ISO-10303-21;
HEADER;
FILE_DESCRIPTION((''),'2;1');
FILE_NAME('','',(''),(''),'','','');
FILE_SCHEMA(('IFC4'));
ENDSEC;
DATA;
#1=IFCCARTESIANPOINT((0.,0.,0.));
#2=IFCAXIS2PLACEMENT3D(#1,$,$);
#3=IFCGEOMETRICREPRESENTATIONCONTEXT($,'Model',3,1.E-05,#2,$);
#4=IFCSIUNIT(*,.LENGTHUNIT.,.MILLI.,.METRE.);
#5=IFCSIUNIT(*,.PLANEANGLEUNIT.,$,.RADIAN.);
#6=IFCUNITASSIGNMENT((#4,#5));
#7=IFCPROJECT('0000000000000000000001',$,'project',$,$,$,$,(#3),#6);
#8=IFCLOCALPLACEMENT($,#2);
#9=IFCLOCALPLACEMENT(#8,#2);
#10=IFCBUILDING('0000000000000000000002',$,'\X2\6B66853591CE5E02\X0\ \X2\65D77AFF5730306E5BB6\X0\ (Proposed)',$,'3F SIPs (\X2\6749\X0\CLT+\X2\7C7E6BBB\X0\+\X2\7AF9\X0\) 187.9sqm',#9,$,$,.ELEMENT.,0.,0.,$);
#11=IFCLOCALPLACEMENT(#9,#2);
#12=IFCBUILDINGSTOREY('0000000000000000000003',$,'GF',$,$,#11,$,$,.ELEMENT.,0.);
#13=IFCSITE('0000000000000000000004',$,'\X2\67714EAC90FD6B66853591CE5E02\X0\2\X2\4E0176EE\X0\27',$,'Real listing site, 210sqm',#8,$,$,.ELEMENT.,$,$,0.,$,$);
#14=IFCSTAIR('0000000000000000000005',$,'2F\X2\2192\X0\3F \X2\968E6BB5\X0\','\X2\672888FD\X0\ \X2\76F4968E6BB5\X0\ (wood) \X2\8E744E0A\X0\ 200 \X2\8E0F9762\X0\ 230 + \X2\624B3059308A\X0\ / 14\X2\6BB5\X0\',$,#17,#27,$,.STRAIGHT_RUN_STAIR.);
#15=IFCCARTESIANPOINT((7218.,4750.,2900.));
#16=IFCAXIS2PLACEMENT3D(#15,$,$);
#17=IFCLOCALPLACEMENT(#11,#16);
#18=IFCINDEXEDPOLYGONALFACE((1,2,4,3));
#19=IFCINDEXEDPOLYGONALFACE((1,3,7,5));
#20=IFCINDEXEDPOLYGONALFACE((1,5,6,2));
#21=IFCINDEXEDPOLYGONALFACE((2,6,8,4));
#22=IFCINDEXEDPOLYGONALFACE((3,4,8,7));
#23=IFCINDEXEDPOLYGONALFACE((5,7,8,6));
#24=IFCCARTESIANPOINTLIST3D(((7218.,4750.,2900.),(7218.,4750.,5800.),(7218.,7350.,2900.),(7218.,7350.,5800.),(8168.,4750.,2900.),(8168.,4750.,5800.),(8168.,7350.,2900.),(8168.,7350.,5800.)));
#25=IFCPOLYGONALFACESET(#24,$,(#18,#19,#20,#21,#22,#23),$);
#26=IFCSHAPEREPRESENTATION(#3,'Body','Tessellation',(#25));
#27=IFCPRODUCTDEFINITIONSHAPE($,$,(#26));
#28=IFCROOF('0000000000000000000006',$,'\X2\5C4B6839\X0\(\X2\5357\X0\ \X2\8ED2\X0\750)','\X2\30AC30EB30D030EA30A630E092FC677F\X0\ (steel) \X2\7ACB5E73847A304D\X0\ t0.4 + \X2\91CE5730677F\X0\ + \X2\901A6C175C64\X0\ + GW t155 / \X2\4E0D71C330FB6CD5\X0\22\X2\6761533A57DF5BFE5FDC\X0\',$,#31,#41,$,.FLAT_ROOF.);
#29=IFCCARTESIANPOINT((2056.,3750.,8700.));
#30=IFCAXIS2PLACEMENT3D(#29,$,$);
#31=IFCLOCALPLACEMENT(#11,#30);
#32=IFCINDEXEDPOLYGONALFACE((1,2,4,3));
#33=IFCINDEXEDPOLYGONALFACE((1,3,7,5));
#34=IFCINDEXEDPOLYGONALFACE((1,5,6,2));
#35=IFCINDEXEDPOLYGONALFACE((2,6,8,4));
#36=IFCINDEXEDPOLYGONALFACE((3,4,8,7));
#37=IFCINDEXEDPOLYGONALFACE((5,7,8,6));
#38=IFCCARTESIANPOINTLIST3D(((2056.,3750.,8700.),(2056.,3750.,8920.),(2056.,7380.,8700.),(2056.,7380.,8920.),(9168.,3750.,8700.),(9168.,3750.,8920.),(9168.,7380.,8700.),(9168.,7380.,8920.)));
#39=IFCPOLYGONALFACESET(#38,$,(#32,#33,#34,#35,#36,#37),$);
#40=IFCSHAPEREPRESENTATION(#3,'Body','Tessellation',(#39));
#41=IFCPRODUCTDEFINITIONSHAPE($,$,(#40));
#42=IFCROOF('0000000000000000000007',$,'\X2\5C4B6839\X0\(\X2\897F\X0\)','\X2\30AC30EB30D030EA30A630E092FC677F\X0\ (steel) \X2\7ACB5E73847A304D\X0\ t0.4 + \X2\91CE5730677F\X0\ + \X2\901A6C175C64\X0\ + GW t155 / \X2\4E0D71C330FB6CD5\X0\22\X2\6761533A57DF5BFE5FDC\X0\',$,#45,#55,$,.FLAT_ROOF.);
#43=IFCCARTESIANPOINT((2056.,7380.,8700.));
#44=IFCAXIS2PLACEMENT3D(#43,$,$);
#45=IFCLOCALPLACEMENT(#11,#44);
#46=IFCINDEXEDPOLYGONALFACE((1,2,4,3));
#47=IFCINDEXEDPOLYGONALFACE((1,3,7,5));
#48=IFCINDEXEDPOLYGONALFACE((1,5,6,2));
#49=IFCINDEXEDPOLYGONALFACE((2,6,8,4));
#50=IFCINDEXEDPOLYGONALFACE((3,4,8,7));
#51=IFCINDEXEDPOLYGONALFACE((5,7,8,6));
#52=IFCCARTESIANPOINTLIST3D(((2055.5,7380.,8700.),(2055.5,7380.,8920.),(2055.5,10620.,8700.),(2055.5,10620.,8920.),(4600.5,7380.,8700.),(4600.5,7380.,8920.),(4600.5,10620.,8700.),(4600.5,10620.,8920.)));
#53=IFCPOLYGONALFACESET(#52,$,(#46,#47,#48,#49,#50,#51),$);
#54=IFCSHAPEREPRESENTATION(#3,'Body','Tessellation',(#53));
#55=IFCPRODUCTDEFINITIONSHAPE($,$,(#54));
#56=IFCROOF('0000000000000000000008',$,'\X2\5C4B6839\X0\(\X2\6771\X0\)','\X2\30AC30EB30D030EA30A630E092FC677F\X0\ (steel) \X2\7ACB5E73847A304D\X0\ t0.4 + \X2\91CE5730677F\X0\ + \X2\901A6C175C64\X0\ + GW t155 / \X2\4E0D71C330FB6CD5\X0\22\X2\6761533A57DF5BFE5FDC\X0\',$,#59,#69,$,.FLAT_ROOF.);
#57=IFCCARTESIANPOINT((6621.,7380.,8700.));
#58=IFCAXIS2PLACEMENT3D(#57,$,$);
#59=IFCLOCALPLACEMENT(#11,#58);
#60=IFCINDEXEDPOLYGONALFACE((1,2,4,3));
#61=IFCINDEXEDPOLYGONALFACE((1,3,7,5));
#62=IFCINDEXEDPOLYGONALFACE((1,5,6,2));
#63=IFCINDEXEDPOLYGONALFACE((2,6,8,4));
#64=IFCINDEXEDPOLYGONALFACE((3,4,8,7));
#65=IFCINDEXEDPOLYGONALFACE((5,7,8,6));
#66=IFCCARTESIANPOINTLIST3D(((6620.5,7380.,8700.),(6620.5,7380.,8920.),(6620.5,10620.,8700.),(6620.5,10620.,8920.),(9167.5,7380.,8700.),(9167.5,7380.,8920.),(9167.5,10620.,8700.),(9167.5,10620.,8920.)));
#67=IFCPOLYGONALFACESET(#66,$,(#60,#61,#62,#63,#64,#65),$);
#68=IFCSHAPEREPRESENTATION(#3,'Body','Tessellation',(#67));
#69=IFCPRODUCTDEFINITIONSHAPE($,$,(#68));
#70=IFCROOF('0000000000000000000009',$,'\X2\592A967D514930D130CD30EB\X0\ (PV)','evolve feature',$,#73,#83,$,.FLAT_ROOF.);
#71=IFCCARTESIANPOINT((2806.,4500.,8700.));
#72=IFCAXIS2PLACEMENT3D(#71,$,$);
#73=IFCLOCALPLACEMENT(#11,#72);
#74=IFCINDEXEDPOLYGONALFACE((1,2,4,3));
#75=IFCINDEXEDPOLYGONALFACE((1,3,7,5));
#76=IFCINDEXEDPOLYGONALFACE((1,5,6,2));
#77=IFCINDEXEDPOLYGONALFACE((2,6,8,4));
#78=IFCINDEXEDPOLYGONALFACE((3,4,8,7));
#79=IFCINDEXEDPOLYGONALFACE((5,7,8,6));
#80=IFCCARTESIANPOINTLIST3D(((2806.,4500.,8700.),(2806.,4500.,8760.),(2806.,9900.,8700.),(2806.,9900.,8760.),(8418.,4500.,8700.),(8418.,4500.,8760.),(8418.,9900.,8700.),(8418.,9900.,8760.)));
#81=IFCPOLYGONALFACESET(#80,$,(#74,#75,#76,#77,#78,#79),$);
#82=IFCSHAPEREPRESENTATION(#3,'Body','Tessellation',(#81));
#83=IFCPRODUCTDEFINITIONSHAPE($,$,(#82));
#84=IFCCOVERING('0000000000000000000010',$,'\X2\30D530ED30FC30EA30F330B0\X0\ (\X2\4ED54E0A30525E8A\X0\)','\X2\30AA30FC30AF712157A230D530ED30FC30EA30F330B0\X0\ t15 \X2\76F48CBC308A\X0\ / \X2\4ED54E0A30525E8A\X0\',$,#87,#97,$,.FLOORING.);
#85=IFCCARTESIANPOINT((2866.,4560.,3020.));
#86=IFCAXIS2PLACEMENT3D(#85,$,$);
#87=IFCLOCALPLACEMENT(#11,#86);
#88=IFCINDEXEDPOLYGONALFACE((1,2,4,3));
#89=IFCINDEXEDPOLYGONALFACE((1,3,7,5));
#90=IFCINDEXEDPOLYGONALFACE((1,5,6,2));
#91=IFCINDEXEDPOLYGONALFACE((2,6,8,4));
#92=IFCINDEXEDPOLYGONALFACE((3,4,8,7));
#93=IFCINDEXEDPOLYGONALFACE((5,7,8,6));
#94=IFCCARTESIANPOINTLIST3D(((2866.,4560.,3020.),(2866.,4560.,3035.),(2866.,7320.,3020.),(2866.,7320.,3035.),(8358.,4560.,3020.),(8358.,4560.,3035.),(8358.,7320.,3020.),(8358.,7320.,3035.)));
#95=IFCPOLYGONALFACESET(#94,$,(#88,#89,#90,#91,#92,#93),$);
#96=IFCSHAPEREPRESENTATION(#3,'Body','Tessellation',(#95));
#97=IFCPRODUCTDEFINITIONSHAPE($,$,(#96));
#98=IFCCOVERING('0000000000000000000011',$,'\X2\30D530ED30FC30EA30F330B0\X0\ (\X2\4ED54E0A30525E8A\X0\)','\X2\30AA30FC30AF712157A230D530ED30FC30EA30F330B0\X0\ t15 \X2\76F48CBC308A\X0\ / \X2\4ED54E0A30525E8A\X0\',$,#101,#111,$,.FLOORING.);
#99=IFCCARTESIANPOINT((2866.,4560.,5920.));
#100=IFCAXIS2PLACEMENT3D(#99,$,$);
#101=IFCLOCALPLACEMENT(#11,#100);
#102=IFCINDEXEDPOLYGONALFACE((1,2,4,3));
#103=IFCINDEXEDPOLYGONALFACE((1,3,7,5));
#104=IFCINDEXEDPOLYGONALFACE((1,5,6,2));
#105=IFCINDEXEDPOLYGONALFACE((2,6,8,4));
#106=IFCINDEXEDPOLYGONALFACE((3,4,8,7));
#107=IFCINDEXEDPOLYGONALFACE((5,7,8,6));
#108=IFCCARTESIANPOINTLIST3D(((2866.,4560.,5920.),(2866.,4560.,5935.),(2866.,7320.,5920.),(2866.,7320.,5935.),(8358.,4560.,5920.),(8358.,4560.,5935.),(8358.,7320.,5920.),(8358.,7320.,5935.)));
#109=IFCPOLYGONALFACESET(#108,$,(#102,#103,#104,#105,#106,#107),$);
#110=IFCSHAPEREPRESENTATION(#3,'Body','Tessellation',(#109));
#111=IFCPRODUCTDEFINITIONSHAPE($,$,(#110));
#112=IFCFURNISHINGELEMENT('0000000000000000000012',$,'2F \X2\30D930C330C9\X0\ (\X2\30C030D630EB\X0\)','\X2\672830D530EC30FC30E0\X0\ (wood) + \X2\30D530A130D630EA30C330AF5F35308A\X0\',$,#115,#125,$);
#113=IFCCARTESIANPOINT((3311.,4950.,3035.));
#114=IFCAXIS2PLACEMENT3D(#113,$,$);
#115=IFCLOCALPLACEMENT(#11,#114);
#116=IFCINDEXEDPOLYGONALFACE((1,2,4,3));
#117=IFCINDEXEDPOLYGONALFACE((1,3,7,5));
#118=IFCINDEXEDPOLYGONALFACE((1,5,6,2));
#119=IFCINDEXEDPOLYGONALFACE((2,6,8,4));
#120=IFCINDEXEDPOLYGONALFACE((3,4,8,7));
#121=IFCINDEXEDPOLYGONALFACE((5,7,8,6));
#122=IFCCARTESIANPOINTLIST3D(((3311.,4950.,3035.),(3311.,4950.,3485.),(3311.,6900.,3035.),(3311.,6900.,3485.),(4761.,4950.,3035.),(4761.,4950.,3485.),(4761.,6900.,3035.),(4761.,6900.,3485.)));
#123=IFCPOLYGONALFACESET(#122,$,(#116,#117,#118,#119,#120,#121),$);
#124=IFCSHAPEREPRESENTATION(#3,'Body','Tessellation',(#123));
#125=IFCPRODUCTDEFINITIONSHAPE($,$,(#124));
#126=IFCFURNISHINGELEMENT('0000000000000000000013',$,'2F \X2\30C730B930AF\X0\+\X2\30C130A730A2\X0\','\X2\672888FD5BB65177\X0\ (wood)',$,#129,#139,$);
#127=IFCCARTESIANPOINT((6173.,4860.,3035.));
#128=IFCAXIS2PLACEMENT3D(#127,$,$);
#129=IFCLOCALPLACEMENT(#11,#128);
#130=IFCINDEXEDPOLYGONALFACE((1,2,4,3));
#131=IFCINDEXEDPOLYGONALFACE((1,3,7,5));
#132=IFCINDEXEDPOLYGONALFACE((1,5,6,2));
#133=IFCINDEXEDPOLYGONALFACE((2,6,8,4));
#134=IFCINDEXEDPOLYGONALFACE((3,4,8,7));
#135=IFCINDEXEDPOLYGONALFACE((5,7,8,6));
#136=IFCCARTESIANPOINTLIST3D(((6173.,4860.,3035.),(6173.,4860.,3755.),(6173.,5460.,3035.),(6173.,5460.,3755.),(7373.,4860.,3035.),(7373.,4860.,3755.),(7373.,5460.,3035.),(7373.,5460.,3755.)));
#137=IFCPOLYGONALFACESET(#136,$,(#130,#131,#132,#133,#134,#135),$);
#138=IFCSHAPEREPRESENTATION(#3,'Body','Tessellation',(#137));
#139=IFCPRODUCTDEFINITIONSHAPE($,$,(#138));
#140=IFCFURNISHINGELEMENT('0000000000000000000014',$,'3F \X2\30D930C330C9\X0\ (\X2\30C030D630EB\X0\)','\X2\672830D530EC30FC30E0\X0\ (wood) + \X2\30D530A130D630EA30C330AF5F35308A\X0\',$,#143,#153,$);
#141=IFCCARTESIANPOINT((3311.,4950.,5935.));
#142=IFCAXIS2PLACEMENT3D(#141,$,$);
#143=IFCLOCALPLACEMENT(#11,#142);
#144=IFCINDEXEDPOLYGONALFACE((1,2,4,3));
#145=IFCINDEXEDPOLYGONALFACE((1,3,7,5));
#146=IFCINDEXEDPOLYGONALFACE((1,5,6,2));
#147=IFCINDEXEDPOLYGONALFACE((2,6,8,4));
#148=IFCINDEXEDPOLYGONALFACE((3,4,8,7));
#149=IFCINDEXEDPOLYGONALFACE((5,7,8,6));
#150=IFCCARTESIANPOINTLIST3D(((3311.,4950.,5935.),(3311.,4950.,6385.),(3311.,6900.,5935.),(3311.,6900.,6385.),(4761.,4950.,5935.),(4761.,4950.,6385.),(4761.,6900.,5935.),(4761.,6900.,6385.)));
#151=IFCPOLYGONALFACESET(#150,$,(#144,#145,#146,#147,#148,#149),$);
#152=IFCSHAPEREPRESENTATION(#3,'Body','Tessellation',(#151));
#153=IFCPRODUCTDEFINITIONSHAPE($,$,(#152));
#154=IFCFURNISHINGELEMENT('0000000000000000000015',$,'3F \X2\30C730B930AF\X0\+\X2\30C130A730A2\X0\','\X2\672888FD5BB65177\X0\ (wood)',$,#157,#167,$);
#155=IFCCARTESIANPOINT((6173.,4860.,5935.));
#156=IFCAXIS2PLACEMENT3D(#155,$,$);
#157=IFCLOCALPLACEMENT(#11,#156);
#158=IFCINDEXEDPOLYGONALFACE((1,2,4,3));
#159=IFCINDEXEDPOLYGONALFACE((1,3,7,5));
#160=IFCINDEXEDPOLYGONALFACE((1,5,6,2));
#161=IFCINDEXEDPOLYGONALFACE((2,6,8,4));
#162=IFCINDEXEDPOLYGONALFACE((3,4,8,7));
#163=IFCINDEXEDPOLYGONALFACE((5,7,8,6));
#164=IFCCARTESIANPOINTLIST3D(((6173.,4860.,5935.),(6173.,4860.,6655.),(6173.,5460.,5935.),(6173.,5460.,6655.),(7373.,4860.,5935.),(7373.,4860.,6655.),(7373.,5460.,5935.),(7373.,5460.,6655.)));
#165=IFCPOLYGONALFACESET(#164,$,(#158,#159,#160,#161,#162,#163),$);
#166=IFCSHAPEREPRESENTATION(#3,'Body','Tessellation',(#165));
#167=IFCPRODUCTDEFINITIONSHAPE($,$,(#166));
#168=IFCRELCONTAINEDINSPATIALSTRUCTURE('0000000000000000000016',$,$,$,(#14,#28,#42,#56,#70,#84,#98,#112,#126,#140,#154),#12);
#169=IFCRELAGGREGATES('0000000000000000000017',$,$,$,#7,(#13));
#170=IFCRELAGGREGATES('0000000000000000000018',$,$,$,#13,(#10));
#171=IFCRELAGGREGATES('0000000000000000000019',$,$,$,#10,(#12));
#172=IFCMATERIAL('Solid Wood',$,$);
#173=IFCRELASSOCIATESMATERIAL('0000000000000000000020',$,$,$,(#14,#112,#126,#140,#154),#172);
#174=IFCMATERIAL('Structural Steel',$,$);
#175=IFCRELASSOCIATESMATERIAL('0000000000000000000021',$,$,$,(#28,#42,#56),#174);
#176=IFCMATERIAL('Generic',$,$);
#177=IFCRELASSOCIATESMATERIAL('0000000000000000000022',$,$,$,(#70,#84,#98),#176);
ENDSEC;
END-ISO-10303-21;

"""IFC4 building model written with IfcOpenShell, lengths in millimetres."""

from ifc_helpers import new_model, si_unit, frame, frame_2d, origin, place, context, project, spatial, rectangle, extrude, material, element, save


model = new_model("IFC4")

# Units and contexts
model_context = context("Model", 3, precision=1e-05, world=origin())
ifc_project = project(units=[si_unit("LENGTHUNIT", "METRE", prefix="MILLI"), si_unit("PLANEANGLEUNIT", "RADIAN")], contexts=[model_context])

# Site, building, storey
site_placement = place(None, origin())
site = spatial("IfcSite", under=ifc_project, at=site_placement, Name="東京都武蔵野市2丁目27", ObjectType="Real listing site, 210sqm", CompositionType="ELEMENT", RefElevation=0.0)
building_placement = place(site_placement, origin())
building = spatial("IfcBuilding", under=site, at=building_placement, Name="武蔵野市 旗竿地の家 (Proposed)", ObjectType="3F SIPs (杉CLT+籾殻+竹) 187.9sqm", CompositionType="ELEMENT", ElevationOfRefHeight=0.0, ElevationOfTerrain=0.0)
storey_placement = place(building_placement, origin())
storey = spatial("IfcBuildingStorey", under=building, at=storey_placement, Name="GF", CompositionType="ELEMENT", Elevation=0.0)

# Shared definitions
ifc_material_1 = material(Name="Solid Wood")

# Stair
stair_placement = place(storey_placement, frame((7218.0, 4750.0, 2900.0)))
element("IfcStair", 1, at=stair_placement, inside=storey, material=ifc_material_1, Name="2F→3F 階段", Description="木製 直階段 (wood) 蹴上 200 踏面 230 + 手すり / 14段", PredefinedType="STRAIGHT_RUN_STAIR", context=model_context, shape_type="SweptSolid", body=[
    extrude(rectangle(XDim=950.0, YDim=2600.0, at=frame_2d((475.0, 1300.0))), frame((7218.0, 4750.0, 2900.0)), (0.0, 0.0, 1.0), 2900.0),
])

# Roofs
ifc_material_2 = material(Name="Structural Steel")
roof_1_placement = place(storey_placement, frame((2056.0, 3750.0, 8700.0)))
element("IfcRoof", 2, at=roof_1_placement, inside=storey, material=ifc_material_2, Name="屋根(南 軒750)", Description="ガルバリウム鋼板 (steel) 立平葺き t0.4 + 野地板 + 通気層 + GW t155 / 不燃・法22条区域対応", PredefinedType="FLAT_ROOF", context=model_context, shape_type="SweptSolid", body=[
    extrude(rectangle(XDim=7112.0, YDim=3630.0, at=frame_2d((3556.0, 1815.0))), frame((2056.0, 3750.0, 8700.0)), (0.0, 0.0, 1.0), 220.0),
])
roof_2_placement = place(storey_placement, frame((2056.0, 7380.0, 8700.0)))
element("IfcRoof", 3, at=roof_2_placement, inside=storey, material=ifc_material_2, Name="屋根(西)", Description="ガルバリウム鋼板 (steel) 立平葺き t0.4 + 野地板 + 通気層 + GW t155 / 不燃・法22条区域対応", PredefinedType="FLAT_ROOF", context=model_context, shape_type="SweptSolid", body=[
    extrude(rectangle(XDim=2545.0, YDim=3240.0, at=frame_2d((1272.0, 1620.0))), frame((2056.0, 7380.0, 8700.0)), (0.0, 0.0, 1.0), 220.0),
])
roof_3_placement = place(storey_placement, frame((6621.0, 7380.0, 8700.0)))
element("IfcRoof", 4, at=roof_3_placement, inside=storey, material=ifc_material_2, Name="屋根(東)", Description="ガルバリウム鋼板 (steel) 立平葺き t0.4 + 野地板 + 通気層 + GW t155 / 不燃・法22条区域対応", PredefinedType="FLAT_ROOF", context=model_context, shape_type="SweptSolid", body=[
    extrude(rectangle(XDim=2547.0, YDim=3240.0, at=frame_2d((1273.0, 1620.0))), frame((6621.0, 7380.0, 8700.0)), (0.0, 0.0, 1.0), 220.0),
])
ifc_material_3 = material(Name="Generic")
roof_4_placement = place(storey_placement, frame((2806.0, 4500.0, 8700.0)))
element("IfcRoof", 5, at=roof_4_placement, inside=storey, material=ifc_material_3, Name="太陽光パネル (PV)", Description="evolve feature", PredefinedType="FLAT_ROOF", context=model_context, shape_type="SweptSolid", body=[
    extrude(rectangle(XDim=5612.0, YDim=5400.0, at=frame_2d((2806.0, 2700.0))), frame((2806.0, 4500.0, 8700.0)), (0.0, 0.0, 1.0), 60.0),
])

# Coverings
covering_1_placement = place(storey_placement, frame((2866.0, 4560.0, 3020.0)))
element("IfcCovering", 6, at=covering_1_placement, inside=storey, material=ifc_material_3, Name="フローリング (仕上げ床)", Description="オーク無垢フローリング t15 直貼り / 仕上げ床", PredefinedType="FLOORING", context=model_context, shape_type="SweptSolid", body=[
    extrude(rectangle(XDim=5492.0, YDim=2760.0, at=frame_2d((2746.0, 1380.0))), frame((2866.0, 4560.0, 3020.0)), (0.0, 0.0, 1.0), 15.0),
])
covering_2_placement = place(storey_placement, frame((2866.0, 4560.0, 5920.0)))
element("IfcCovering", 7, at=covering_2_placement, inside=storey, material=ifc_material_3, Name="フローリング (仕上げ床)", Description="オーク無垢フローリング t15 直貼り / 仕上げ床", PredefinedType="FLOORING", context=model_context, shape_type="SweptSolid", body=[
    extrude(rectangle(XDim=5492.0, YDim=2760.0, at=frame_2d((2746.0, 1380.0))), frame((2866.0, 4560.0, 5920.0)), (0.0, 0.0, 1.0), 15.0),
])

# Furnishing elements
furnishing_1_placement = place(storey_placement, frame((3311.0, 4950.0, 3035.0)))
element("IfcFurnishingElement", 8, at=furnishing_1_placement, inside=storey, material=ifc_material_1, Name="2F ベッド (ダブル)", Description="木フレーム (wood) + ファブリック張り", context=model_context, shape_type="SweptSolid", body=[
    extrude(rectangle(XDim=1450.0, YDim=1950.0, at=frame_2d((725.0, 975.0))), frame((3311.0, 4950.0, 3035.0)), (0.0, 0.0, 1.0), 450.0),
])
furnishing_2_placement = place(storey_placement, frame((6173.0, 4860.0, 3035.0)))
element("IfcFurnishingElement", 9, at=furnishing_2_placement, inside=storey, material=ifc_material_1, Name="2F デスク+チェア", Description="木製家具 (wood)", context=model_context, shape_type="SweptSolid", body=[
    extrude(rectangle(XDim=1200.0, YDim=600.0, at=frame_2d((600.0, 300.0))), frame((6173.0, 4860.0, 3035.0)), (0.0, 0.0, 1.0), 720.0),
])
furnishing_3_placement = place(storey_placement, frame((3311.0, 4950.0, 5935.0)))
element("IfcFurnishingElement", 10, at=furnishing_3_placement, inside=storey, material=ifc_material_1, Name="3F ベッド (ダブル)", Description="木フレーム (wood) + ファブリック張り", context=model_context, shape_type="SweptSolid", body=[
    extrude(rectangle(XDim=1450.0, YDim=1950.0, at=frame_2d((725.0, 975.0))), frame((3311.0, 4950.0, 5935.0)), (0.0, 0.0, 1.0), 450.0),
])
furnishing_4_placement = place(storey_placement, frame((6173.0, 4860.0, 5935.0)))
element("IfcFurnishingElement", 11, at=furnishing_4_placement, inside=storey, material=ifc_material_1, Name="3F デスク+チェア", Description="木製家具 (wood)", context=model_context, shape_type="SweptSolid", body=[
    extrude(rectangle(XDim=1200.0, YDim=600.0, at=frame_2d((600.0, 300.0))), frame((6173.0, 4860.0, 5935.0)), (0.0, 0.0, 1.0), 720.0),
])

save(model, "model.ifc")
